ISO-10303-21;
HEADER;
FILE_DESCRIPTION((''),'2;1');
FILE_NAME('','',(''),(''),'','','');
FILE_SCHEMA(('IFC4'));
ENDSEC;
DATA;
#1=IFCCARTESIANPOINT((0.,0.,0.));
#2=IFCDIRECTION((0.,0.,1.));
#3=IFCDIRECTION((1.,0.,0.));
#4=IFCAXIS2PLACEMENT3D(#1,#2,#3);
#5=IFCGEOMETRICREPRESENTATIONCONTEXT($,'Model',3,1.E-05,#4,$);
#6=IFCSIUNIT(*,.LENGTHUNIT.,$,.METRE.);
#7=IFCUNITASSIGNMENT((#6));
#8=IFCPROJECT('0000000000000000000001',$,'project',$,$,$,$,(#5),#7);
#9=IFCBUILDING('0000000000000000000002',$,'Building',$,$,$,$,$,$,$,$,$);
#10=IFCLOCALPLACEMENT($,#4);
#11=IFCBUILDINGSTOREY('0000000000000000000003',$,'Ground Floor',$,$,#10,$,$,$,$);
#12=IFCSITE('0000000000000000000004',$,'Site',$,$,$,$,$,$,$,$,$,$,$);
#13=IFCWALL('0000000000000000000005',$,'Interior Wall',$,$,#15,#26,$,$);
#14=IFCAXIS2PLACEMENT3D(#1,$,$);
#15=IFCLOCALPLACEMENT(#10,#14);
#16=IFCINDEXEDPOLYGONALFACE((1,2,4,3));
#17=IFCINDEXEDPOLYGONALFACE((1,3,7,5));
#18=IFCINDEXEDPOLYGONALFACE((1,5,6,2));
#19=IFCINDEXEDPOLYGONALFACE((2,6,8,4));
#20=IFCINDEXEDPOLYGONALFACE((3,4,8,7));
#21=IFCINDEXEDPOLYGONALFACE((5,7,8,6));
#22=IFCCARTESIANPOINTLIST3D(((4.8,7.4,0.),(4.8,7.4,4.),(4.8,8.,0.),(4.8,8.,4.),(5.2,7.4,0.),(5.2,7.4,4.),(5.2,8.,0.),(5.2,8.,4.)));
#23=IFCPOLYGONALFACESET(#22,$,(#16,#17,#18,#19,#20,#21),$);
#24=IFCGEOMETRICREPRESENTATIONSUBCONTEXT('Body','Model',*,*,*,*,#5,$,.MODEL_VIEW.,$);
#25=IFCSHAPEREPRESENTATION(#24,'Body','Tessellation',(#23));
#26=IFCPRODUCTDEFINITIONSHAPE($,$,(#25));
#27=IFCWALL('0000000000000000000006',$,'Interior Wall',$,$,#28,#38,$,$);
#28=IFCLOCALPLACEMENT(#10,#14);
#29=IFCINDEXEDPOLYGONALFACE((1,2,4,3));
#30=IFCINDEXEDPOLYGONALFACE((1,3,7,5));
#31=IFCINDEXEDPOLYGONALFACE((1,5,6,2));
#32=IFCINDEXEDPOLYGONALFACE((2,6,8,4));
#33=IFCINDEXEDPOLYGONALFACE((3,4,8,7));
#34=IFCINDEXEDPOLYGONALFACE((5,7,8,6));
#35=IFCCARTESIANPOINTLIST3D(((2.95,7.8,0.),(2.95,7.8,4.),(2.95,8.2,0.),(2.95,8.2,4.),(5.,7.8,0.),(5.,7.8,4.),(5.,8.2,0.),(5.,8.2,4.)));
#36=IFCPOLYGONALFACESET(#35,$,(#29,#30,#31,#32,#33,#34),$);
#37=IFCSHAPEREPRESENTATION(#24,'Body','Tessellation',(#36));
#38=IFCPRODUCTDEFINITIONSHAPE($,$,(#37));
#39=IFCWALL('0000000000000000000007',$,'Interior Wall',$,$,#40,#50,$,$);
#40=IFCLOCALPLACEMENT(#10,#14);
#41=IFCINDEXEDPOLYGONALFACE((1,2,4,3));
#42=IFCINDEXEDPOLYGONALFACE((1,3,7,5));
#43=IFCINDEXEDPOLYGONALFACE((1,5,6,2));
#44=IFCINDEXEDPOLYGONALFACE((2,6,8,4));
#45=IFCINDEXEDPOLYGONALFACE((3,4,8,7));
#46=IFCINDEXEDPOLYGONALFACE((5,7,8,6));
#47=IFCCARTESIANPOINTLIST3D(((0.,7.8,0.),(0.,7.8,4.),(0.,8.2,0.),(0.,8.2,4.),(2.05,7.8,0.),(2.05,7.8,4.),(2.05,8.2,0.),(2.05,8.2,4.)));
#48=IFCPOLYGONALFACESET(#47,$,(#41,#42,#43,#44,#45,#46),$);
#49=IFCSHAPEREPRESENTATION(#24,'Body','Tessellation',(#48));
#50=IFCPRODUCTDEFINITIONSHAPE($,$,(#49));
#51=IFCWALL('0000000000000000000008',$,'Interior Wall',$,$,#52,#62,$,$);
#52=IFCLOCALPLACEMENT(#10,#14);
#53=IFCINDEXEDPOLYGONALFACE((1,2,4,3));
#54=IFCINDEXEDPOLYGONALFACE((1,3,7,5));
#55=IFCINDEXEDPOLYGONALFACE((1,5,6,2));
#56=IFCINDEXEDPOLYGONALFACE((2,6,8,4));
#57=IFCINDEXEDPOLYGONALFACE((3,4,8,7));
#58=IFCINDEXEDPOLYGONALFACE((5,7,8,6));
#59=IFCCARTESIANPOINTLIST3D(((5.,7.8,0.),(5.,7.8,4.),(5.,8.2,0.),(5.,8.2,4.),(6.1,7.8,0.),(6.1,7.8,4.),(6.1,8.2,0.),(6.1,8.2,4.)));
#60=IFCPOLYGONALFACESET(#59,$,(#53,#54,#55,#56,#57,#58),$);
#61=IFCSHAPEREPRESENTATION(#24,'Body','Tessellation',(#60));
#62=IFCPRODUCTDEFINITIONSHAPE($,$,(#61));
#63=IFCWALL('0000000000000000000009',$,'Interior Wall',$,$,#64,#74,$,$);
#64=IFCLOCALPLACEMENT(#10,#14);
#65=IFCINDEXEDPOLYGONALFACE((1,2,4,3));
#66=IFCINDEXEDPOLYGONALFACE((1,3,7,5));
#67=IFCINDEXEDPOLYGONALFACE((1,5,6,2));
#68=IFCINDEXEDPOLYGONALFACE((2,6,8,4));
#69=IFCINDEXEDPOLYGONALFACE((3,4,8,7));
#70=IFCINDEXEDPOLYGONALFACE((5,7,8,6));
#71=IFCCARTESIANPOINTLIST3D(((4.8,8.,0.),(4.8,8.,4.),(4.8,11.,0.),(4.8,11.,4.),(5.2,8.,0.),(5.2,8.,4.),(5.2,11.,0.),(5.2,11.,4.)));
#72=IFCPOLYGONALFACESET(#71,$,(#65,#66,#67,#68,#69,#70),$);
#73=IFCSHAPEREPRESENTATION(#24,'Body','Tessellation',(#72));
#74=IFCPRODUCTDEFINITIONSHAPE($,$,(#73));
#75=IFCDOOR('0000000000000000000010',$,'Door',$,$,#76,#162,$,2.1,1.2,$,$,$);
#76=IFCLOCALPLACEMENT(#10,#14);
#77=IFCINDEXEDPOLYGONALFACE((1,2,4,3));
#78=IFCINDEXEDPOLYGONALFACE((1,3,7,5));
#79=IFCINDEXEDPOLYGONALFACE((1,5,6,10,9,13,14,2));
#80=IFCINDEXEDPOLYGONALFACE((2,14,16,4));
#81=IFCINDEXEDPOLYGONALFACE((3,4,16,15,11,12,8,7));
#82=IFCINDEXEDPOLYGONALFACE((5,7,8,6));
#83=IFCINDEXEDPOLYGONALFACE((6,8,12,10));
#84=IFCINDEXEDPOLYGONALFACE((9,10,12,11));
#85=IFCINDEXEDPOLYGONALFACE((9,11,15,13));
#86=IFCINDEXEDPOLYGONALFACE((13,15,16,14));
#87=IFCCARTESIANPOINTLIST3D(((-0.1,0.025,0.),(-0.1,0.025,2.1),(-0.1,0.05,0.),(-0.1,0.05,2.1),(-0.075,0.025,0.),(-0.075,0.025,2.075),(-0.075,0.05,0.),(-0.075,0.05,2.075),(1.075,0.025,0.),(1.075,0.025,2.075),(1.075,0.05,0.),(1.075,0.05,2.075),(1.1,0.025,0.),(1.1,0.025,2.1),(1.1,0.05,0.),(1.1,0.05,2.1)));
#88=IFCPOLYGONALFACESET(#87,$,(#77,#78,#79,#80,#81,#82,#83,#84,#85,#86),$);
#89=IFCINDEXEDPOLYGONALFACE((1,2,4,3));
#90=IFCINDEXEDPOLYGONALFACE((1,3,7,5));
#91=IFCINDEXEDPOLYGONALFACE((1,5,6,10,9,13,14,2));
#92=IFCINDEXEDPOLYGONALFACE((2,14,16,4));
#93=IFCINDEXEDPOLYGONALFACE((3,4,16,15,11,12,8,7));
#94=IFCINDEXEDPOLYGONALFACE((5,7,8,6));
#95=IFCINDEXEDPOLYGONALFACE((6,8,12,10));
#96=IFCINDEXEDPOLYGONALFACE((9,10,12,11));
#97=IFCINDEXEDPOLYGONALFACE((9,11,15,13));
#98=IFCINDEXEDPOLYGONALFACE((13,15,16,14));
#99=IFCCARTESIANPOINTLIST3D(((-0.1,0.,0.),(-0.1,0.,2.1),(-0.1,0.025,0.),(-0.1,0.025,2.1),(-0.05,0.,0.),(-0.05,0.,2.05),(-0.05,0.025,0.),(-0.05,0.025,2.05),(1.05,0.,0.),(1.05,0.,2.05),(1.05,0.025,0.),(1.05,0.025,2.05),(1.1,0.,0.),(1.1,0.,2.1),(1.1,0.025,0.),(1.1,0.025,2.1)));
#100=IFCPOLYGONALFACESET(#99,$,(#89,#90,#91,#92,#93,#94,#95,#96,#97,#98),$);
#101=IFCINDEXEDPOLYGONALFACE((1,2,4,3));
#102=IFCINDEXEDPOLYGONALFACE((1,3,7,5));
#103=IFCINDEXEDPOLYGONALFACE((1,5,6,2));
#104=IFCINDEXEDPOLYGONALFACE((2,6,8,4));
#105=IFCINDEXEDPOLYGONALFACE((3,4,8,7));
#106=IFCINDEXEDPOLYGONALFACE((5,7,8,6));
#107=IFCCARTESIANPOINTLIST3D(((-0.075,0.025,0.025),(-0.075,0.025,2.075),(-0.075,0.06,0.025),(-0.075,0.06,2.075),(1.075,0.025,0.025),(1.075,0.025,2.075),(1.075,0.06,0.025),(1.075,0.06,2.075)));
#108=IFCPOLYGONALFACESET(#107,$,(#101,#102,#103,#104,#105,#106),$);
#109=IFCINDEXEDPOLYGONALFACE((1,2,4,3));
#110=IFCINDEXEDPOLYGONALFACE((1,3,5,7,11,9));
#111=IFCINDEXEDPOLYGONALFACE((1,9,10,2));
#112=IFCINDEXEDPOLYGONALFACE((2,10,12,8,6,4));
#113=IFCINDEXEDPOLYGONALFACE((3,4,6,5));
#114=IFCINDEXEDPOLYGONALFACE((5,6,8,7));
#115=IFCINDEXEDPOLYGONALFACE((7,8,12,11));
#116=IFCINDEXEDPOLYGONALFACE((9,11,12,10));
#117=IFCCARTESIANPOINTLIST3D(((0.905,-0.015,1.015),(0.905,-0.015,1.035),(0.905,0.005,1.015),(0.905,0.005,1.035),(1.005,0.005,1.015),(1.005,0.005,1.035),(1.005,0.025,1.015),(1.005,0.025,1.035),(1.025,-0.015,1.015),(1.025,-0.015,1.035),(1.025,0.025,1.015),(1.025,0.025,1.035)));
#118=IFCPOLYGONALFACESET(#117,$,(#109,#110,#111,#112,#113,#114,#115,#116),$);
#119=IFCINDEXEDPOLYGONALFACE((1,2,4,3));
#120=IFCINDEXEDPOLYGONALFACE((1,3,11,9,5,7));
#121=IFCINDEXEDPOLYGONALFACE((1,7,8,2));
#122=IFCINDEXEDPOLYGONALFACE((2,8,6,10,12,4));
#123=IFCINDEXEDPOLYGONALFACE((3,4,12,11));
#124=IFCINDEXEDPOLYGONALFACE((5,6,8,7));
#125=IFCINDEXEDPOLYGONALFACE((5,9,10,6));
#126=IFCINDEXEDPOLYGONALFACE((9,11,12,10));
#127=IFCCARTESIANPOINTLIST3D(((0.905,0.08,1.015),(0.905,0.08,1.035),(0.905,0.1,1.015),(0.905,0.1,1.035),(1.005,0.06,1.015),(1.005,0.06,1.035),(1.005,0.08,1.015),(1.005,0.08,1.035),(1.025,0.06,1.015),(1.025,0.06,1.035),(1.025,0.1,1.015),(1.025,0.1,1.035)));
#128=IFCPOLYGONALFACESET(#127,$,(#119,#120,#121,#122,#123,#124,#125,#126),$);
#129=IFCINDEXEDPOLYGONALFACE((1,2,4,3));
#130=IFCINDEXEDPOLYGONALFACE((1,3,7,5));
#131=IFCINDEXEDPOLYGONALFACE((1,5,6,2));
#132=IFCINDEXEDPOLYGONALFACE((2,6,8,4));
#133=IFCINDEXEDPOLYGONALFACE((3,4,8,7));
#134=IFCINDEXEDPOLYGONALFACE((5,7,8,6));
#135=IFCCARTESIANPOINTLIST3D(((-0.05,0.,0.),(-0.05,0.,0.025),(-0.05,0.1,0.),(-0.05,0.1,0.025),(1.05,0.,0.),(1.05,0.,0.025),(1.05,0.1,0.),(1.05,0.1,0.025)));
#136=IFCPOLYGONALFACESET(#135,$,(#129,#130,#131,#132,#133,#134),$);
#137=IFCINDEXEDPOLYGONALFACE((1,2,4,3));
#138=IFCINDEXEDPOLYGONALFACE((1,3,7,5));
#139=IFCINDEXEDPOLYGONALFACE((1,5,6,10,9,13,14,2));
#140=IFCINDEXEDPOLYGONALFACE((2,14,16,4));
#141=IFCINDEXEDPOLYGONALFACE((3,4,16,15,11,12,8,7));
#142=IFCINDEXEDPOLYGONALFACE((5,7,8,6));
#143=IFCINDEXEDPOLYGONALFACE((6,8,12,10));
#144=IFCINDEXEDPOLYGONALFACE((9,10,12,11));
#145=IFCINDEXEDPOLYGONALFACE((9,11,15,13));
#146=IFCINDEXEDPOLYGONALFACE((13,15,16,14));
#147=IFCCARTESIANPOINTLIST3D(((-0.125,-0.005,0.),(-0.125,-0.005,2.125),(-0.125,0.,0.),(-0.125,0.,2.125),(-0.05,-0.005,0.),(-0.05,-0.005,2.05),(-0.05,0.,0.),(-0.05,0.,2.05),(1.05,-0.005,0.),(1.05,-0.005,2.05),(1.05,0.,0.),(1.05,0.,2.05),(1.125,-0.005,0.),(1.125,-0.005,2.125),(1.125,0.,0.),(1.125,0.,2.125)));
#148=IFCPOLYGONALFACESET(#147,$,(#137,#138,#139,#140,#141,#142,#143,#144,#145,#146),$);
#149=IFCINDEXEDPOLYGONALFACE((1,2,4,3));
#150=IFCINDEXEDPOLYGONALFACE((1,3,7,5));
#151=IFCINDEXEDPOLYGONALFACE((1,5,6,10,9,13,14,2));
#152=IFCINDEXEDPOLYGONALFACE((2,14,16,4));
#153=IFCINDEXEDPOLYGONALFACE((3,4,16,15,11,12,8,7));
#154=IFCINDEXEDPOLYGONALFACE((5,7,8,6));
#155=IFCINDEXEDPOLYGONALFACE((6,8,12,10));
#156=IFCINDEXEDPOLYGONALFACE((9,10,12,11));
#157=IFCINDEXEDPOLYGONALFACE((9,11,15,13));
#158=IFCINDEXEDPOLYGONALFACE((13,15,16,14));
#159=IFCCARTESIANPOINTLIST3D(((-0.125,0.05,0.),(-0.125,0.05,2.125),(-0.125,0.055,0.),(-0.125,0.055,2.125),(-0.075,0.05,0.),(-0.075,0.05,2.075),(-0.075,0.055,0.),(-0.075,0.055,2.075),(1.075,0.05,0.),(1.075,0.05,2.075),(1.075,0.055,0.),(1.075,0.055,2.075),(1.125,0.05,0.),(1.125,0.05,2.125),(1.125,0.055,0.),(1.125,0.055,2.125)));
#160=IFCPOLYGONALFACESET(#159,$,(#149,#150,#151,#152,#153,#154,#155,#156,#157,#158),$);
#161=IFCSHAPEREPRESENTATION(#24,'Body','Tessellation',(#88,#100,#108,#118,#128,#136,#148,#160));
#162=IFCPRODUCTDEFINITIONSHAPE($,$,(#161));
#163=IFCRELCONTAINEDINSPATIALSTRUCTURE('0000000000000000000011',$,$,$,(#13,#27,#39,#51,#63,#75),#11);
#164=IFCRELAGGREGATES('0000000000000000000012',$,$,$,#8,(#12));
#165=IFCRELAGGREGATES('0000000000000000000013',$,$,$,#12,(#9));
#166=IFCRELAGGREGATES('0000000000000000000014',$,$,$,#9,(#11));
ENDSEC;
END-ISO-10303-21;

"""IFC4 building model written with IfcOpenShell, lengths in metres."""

from ifc_helpers import new_model, si_unit, frame, origin_with_axes, place, context, subcontext, project, spatial, line, indexed_curve, outline, extrude, element, save


model = new_model("IFC4")

# Units and contexts
model_context = context("Model", 3, precision=1e-05, world=origin_with_axes())
body_context = subcontext(model_context, "Body", "Model", "MODEL_VIEW")
ifc_project = project(units=[si_unit("LENGTHUNIT", "METRE")], contexts=[model_context])

# Site, building, storey
site = spatial("IfcSite", under=ifc_project, Name="Site")
building = spatial("IfcBuilding", under=site, Name="Building")
storey_placement = place(None, origin_with_axes())
storey = spatial("IfcBuildingStorey", under=building, at=storey_placement, Name="Ground Floor")

# Walls
wall_1_placement = place(storey_placement, frame((5.0, 7.4, 0.0), z_axis=(0.0, 0.0, 1.0), x_axis=(0.0, 1.0, 0.0)))
element("IfcWall", 1, at=wall_1_placement, inside=storey, Name="Interior Wall", context=body_context, shape_type="SweptSolid", body=[
    extrude(outline(indexed_curve([(0.0, 0.0), (0.0, 0.4), (0.6, 0.4), (0.6, 0.0), (0.0, 0.0)], self_intersect=False)), frame((0.0, -0.2, 0.0), z_axis=(0.0, 0.0, 1.0), x_axis=(1.0, 0.0, 0.0)), (0.0, 0.0, 1.0), 4.0),
])
for number, where, z_axis, x_axis, name in (
    (2, (5.0, 8.0, 0.0), (0.0, 0.0, 1.0), (-1.0, 0.0, 0.0), "Interior Wall"),
    (3, (2.05, 8.0, 0.0), (0.0, 0.0, 1.0), (-1.0, 0.0, 0.0), "Interior Wall"),
):
    element("IfcWall", number, at=place(storey_placement, frame(where, z_axis=z_axis, x_axis=x_axis)), inside=storey, Name=name, context=body_context, shape_type="SweptSolid", body=[
        extrude(outline(indexed_curve([(0.0, 0.0), (0.0, 0.4), (2.05, 0.4), (2.05, 0.0), (0.0, 0.0)], self_intersect=False)), frame((0.0, -0.2, 0.0), z_axis=(0.0, 0.0, 1.0), x_axis=(1.0, 0.0, 0.0)), (0.0, 0.0, 1.0), 4.0),
    ])
wall_2_placement = place(storey_placement, frame((6.1, 8.0, 0.0), z_axis=(0.0, 0.0, 1.0), x_axis=(-1.0, 0.0, 0.0)))
element("IfcWall", 4, at=wall_2_placement, inside=storey, Name="Interior Wall", context=body_context, shape_type="SweptSolid", body=[
    extrude(outline(indexed_curve([(0.0, 0.0), (0.0, 0.4), (1.1, 0.4), (1.1, 0.0), (0.0, 0.0)], self_intersect=False)), frame((0.0, -0.2, 0.0), z_axis=(0.0, 0.0, 1.0), x_axis=(1.0, 0.0, 0.0)), (0.0, 0.0, 1.0), 4.0),
])
wall_3_placement = place(storey_placement, frame((5.0, 8.0, 0.0), z_axis=(0.0, 0.0, 1.0), x_axis=(0.0, 1.0, 0.0)))
element("IfcWall", 5, at=wall_3_placement, inside=storey, Name="Interior Wall", context=body_context, shape_type="SweptSolid", body=[
    extrude(outline(indexed_curve([(0.0, 0.0), (0.0, 0.4), (3.0, 0.4), (3.0, 0.0), (0.0, 0.0)], self_intersect=False)), frame((0.0, -0.2, 0.0), z_axis=(0.0, 0.0, 1.0), x_axis=(1.0, 0.0, 0.0)), (0.0, 0.0, 1.0), 4.0),
])

# Door
door_1_placement = place(storey_placement, frame((-0.1, 0.0, 0.0), z_axis=(0.0, 0.0, 1.0), x_axis=(1.0, 0.0, 0.0)))
element("IfcDoor", 6, at=door_1_placement, inside=storey, Name="Door", OverallHeight=2.1, OverallWidth=1.2, context=body_context, shape_type="SweptSolid", body=[
    extrude(outline(indexed_curve([(0.0, 0.0), (0.0, 2.1), (1.2, 2.1), (1.2, 0.0), (1.175, 0.0), (1.175, 2.075), (0.025, 2.075), (0.025, 0.0)], segments=[line(1, 2, 3, 4, 5, 6, 7, 8, 1)])), frame((0.0, 0.025, 0.0), z_axis=(0.0, -1.0, 0.0), x_axis=(1.0, 0.0, 0.0)), (0.0, 0.0, -1.0), 0.025),
    extrude(outline(indexed_curve([(0.0, 0.0), (0.0, 2.1), (1.2, 2.1), (1.2, 0.0), (1.15, 0.0), (1.15, 2.05), (0.05, 2.05), (0.05, 0.0)], segments=[line(1, 2, 3, 4, 5, 6, 7, 8, 1)])), frame((0.0, 0.0, 0.0), z_axis=(0.0, -1.0, 0.0), x_axis=(1.0, 0.0, 0.0)), (0.0, 0.0, -1.0), 0.025),
    extrude(outline(indexed_curve([(0.0, 0.0), (1.15, 0.0), (1.15, 0.035), (0.0, 0.035)], segments=[line(1, 2, 3, 4, 1)])), frame((0.025, 0.025, 0.025), z_axis=(0.0, 0.0, 1.0), x_axis=(1.0, 0.0, 0.0)), (0.0, 0.0, 1.0), 2.05),
    extrude(outline(indexed_curve([(0.0, 0.0), (0.0, -0.04), (-0.12, -0.04), (-0.12, -0.02), (-0.02, -0.02), (-0.02, 0.0)], segments=[line(1, 2, 3, 4, 5, 6, 1)])), frame((1.125, 0.025, 1.015), z_axis=(0.0, 0.0, 1.0), x_axis=(1.0, 0.0, 0.0)), (0.0, 0.0, 1.0), 0.02),
    extrude(outline(indexed_curve([(0.0, 0.0), (0.0, 0.04), (-0.12, 0.04), (-0.12, 0.02), (-0.02, 0.02), (-0.02, 0.0)], segments=[line(1, 2, 3, 4, 5, 6, 1)])), frame((1.125, 0.06, 1.015), z_axis=(0.0, 0.0, 1.0), x_axis=(1.0, 0.0, 0.0)), (0.0, 0.0, 1.0), 0.02),
    extrude(outline(indexed_curve([(0.0, 0.0), (1.1, 0.0), (1.1, 0.1), (0.0, 0.1)], segments=[line(1, 2, 3, 4, 1)])), frame((0.05, 0.0, 0.0), z_axis=(0.0, 0.0, 1.0), x_axis=(1.0, 0.0, 0.0)), (0.0, 0.0, 1.0), 0.025),
    extrude(outline(indexed_curve([(0.0, 0.0), (0.0, 2.125), (1.25, 2.125), (1.25, 0.0), (1.175, 0.0), (1.175, 2.05), (0.075, 2.05), (0.075, 0.0)], segments=[line(1, 2, 3, 4, 5, 6, 7, 8, 1)])), frame((-0.025, -0.005, 0.0), z_axis=(0.0, -1.0, 0.0), x_axis=(1.0, 0.0, 0.0)), (0.0, 0.0, -1.0), 0.005),
    extrude(outline(indexed_curve([(0.0, 0.0), (0.0, 2.125), (1.25, 2.125), (1.25, 0.0), (1.2, 0.0), (1.2, 2.075), (0.05, 2.075), (0.05, 0.0)], segments=[line(1, 2, 3, 4, 5, 6, 7, 8, 1)])), frame((-0.025, 0.05, 0.0), z_axis=(0.0, -1.0, 0.0), x_axis=(1.0, 0.0, 0.0)), (0.0, 0.0, -1.0), 0.005),
])

save(model, "model.ifc")
